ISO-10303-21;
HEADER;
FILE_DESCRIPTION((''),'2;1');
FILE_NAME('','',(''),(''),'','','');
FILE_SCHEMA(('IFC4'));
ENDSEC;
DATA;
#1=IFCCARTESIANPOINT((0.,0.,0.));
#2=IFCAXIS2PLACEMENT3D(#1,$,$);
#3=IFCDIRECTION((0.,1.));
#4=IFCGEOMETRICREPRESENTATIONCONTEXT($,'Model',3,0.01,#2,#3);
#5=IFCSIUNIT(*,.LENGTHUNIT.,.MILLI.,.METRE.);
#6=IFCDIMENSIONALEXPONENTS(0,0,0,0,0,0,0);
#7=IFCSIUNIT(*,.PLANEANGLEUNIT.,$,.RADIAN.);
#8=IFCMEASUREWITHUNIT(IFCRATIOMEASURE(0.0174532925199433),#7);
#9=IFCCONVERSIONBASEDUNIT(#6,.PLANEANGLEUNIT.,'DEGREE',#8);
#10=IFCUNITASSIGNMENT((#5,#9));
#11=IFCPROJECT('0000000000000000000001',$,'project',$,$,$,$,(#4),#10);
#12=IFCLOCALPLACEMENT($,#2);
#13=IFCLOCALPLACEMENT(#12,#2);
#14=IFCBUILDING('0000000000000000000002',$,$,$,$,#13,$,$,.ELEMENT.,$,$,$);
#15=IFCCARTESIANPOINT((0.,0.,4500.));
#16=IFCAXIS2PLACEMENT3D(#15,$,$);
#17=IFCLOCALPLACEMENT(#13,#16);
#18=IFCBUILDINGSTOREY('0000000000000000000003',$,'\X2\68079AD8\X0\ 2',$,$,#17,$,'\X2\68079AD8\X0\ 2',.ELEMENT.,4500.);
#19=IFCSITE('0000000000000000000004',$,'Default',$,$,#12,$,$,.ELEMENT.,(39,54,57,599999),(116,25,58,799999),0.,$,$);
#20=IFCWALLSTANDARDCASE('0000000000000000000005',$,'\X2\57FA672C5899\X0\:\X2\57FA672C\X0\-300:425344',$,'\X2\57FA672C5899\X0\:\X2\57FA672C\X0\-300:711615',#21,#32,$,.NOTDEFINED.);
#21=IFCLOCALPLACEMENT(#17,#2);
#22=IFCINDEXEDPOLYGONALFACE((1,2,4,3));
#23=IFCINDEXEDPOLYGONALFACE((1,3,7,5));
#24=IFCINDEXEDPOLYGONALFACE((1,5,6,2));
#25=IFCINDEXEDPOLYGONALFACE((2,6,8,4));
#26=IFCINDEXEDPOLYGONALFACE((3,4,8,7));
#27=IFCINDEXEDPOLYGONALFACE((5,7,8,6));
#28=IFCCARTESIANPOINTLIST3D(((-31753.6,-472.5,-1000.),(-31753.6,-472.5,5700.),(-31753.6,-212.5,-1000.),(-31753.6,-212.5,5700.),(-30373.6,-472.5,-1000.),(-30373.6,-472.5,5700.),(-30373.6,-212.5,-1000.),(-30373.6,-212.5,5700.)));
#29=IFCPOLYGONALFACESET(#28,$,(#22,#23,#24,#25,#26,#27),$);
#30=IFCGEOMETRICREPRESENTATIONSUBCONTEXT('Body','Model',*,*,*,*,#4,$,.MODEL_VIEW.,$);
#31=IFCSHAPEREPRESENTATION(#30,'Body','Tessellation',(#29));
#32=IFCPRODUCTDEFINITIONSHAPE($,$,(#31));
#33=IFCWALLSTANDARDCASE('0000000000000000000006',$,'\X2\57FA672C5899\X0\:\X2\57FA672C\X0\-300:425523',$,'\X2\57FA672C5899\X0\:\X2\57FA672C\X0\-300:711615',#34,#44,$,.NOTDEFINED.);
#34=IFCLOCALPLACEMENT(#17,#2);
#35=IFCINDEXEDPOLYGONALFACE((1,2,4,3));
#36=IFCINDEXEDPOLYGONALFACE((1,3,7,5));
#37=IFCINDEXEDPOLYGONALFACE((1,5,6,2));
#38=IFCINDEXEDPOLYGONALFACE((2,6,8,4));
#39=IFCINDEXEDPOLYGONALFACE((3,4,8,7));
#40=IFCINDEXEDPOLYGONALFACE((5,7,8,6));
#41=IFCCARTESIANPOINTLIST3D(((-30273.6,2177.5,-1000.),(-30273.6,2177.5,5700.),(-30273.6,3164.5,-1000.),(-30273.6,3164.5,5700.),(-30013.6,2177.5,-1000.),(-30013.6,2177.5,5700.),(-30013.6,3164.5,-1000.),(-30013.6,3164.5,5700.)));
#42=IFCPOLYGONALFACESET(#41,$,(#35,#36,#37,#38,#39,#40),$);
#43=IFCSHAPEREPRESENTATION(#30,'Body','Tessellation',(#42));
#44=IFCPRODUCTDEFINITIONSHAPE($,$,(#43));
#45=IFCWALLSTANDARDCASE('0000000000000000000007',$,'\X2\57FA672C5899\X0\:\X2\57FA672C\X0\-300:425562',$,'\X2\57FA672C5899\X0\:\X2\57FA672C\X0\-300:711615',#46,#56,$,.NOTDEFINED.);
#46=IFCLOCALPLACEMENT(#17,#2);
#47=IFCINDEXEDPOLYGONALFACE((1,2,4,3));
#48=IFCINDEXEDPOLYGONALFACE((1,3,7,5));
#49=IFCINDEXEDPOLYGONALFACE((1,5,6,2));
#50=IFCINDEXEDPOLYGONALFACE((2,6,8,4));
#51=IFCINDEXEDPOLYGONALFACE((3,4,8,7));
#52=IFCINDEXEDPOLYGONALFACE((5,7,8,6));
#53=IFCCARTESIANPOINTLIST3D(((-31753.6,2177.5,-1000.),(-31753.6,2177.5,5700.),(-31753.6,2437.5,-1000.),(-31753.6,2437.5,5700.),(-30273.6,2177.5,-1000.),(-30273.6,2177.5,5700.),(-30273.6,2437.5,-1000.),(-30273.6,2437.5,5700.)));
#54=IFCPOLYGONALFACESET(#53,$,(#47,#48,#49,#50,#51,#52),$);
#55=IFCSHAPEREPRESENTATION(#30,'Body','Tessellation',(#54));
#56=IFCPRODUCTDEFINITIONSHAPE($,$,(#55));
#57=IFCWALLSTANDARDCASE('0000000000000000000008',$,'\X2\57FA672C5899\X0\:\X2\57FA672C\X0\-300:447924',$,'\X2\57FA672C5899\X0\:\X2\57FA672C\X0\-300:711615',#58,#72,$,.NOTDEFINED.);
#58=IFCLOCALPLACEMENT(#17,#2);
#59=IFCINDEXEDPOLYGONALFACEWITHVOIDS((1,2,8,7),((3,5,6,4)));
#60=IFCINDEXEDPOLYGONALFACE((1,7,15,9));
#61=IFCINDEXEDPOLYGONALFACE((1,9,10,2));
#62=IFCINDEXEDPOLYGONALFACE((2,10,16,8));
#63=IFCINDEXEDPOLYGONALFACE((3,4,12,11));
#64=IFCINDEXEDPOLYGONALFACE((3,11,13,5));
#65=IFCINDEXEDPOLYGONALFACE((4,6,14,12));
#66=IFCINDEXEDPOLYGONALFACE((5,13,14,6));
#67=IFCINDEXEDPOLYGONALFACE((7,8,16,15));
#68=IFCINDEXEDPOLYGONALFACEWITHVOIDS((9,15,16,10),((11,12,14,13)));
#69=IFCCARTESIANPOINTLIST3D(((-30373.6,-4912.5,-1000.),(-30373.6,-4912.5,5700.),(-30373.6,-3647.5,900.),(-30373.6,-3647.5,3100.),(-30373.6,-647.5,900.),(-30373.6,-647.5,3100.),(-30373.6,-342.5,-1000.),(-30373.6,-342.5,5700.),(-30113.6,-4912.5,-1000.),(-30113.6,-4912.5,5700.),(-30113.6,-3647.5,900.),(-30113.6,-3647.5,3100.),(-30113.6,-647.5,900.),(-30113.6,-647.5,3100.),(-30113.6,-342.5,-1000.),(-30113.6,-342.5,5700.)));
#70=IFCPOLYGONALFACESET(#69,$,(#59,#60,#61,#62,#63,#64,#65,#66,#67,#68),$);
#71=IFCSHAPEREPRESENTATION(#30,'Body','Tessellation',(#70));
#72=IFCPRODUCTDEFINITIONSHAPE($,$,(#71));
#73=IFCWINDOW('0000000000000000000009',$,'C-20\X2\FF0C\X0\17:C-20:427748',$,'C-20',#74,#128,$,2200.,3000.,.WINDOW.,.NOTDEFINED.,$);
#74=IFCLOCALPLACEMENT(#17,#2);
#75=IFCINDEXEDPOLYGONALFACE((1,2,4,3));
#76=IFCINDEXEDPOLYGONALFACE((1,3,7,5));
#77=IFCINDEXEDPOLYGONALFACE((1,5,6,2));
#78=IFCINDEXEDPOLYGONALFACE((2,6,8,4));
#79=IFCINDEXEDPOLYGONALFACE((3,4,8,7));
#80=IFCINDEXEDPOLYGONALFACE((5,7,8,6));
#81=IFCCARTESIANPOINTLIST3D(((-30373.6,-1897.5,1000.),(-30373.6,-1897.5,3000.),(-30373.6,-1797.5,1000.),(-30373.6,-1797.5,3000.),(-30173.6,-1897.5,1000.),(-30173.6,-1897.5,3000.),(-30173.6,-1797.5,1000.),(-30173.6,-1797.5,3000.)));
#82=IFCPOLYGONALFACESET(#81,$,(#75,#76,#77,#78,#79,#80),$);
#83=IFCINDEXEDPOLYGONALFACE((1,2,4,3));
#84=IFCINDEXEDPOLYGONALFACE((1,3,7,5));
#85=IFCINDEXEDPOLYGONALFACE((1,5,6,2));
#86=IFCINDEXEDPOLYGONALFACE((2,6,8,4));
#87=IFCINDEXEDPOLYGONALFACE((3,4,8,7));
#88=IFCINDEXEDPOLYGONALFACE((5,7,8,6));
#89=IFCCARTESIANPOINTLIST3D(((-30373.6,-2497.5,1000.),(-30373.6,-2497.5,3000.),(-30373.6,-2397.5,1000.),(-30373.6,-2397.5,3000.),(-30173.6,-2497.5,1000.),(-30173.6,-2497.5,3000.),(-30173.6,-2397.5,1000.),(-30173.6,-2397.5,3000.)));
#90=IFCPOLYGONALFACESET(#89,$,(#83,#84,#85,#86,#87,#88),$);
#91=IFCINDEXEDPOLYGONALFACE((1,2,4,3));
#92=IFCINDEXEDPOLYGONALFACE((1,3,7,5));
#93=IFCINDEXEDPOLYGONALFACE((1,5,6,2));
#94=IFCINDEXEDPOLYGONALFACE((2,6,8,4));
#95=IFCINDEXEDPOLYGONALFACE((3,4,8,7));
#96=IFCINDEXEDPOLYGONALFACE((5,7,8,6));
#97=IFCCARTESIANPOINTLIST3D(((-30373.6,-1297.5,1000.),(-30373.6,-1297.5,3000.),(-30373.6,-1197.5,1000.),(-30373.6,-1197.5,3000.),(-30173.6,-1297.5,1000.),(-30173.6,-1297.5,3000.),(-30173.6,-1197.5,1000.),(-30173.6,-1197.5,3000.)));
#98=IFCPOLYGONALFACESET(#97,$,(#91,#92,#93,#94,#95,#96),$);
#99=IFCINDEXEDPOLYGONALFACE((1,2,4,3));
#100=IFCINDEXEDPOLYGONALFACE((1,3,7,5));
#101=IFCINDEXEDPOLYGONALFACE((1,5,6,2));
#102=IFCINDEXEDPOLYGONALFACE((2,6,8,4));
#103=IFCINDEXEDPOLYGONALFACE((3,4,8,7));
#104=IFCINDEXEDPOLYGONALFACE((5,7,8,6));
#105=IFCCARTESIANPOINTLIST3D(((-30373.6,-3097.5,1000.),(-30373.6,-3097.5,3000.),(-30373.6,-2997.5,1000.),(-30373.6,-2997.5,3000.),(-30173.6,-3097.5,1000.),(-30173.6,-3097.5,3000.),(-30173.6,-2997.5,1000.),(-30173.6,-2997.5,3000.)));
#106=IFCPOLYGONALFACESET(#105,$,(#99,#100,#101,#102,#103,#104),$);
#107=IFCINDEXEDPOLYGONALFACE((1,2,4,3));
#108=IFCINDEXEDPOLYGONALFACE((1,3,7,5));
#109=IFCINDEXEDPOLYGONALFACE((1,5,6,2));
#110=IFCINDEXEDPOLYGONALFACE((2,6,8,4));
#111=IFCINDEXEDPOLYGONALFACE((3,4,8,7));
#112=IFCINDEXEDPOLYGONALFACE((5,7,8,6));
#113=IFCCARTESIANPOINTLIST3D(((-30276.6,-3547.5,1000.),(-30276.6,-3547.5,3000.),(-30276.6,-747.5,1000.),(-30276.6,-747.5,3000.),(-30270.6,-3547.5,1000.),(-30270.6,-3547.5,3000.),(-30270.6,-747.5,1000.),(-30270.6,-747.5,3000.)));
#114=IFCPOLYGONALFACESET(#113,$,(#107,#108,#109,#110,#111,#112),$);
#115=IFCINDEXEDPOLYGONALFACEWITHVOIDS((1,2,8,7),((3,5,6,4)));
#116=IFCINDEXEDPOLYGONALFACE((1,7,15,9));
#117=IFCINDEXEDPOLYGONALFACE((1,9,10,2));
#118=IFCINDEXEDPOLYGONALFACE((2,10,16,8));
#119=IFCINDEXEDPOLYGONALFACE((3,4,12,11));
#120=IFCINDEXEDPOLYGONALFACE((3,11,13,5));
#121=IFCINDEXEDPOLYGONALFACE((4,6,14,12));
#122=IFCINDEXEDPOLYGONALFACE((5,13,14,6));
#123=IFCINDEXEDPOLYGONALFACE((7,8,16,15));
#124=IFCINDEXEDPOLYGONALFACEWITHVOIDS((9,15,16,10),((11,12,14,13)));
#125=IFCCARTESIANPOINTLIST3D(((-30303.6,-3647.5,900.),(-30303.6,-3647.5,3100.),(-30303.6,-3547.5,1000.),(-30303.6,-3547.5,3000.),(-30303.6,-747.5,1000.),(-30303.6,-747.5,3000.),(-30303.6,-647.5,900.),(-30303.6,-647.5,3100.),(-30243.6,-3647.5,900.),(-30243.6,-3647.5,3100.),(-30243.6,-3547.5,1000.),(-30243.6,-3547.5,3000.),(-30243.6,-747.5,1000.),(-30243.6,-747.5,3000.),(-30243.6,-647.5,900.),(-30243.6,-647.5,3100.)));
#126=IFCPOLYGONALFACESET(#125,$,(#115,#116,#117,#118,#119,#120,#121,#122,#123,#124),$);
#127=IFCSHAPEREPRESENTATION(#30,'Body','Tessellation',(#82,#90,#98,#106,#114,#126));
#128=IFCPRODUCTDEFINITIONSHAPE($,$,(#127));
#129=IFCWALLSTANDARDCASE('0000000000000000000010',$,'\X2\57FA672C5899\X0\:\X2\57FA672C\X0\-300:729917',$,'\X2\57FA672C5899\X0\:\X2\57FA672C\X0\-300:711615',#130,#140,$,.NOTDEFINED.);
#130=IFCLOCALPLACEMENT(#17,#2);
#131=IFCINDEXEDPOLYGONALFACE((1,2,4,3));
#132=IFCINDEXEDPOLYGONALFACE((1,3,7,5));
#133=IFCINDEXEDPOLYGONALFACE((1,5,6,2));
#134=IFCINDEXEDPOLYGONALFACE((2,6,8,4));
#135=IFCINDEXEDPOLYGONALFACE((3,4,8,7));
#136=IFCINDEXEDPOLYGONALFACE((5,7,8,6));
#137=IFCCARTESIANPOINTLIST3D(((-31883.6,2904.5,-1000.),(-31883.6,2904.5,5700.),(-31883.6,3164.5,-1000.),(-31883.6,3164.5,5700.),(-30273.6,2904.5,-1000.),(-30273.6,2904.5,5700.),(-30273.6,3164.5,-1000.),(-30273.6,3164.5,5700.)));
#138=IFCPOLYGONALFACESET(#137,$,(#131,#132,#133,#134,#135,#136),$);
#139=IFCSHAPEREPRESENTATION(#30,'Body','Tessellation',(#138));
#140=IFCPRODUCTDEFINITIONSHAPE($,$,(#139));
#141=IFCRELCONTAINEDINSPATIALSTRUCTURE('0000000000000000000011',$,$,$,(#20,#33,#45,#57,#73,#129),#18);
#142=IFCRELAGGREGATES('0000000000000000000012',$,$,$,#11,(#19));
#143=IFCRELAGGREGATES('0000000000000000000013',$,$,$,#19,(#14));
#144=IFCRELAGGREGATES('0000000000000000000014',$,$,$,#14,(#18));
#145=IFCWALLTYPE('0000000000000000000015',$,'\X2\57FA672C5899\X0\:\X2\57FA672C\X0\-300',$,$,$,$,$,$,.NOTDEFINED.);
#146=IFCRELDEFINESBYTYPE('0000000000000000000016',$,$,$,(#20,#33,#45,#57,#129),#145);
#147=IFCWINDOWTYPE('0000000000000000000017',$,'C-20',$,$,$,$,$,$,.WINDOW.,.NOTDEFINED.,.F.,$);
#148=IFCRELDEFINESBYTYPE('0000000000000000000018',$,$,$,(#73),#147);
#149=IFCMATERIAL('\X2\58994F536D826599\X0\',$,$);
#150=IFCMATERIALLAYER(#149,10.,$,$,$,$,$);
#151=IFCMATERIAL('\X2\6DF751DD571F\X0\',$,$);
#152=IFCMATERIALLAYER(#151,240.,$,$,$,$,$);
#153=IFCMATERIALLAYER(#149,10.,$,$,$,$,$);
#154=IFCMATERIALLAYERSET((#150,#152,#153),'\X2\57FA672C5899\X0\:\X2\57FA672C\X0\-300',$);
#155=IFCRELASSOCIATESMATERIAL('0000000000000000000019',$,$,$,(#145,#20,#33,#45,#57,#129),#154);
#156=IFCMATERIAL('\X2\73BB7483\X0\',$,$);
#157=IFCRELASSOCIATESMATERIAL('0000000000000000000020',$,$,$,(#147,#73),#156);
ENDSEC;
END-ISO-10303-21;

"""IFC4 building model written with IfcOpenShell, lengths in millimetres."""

from ifc_helpers import new_model, entity, si_unit, converted_unit, direction, frame, frame_2d, origin, origin_2d_with_axis, place, context, subcontext, project, spatial, polyline, rectangle, outline, extrude, source, transform, mapped, material, layer, layer_set, layer_usage, type_object, type_shapes, element, fill, save


model = new_model("IFC4")

# Units and contexts
model_context = context("Model", 3, precision=0.01, world=origin(), true_north=direction((0.0, 1.0)))
body_context = subcontext(model_context, "Body", "Model", "MODEL_VIEW")
ifc_project = project(units=[si_unit("LENGTHUNIT", "METRE", prefix="MILLI"), converted_unit("PLANEANGLEUNIT", "DEGREE", entity("IfcRatioMeasure", 0.0174532925199433), si_unit("PLANEANGLEUNIT", "RADIAN"), dimensions=[0, 0, 0, 0, 0, 0, 0])], contexts=[model_context])

# Site, building, storey
site_placement = place(None, origin())
site = spatial("IfcSite", under=ifc_project, at=site_placement, Name="Default", CompositionType="ELEMENT", RefLatitude=(39, 54, 57, 599999), RefLongitude=(116, 25, 58, 799999), RefElevation=0.0)
building_placement = place(site_placement, origin())
building = spatial("IfcBuilding", under=site, at=building_placement, CompositionType="ELEMENT")
storey_placement = place(building_placement, frame((0.0, 0.0, 4500.0)))
storey = spatial("IfcBuildingStorey", under=building, at=storey_placement, Name="标高 2", LongName="标高 2", CompositionType="ELEMENT", Elevation=4500.0)

# Shared definitions
ifc_material_1 = material(Name="混凝土")

# Shared definitions
ifc_material_2 = material(Name="墙体涂料")
ifc_layer_1 = layer(ifc_material_2, 10.0)
ifc_layer_2 = layer(ifc_material_1, 240.0)
ifc_layer_3 = layer(ifc_material_2, 10.0)
ifc_layer_set_1 = layer_set([ifc_layer_1, ifc_layer_2, ifc_layer_3], Name="基本墙:基本-300")
wall_type = type_object("IfcWallType", Name="基本墙:基本-300", PredefinedType="NOTDEFINED", material=ifc_layer_set_1)
ifc_material_3 = material(Name="玻璃")

# Walls
ifc_layer_usage_1 = layer_usage(ifc_layer_set_1, "AXIS2", "POSITIVE", -130.0)
wall_1_placement = place(storey_placement, frame((-31753.6, -342.5, -1000.0)))
element("IfcWallStandardCase", 1, at=wall_1_placement, inside=storey, type_object=wall_type, material=ifc_layer_usage_1, Name="基本墙:基本-300:425344", ObjectType="基本墙:基本-300:711615", PredefinedType="NOTDEFINED", context=body_context, shape_type="SweptSolid", body=[
    extrude(rectangle(XDim=1380.0, YDim=260.0, at=frame_2d((690.0, 0.0), x_axis=(-1.0, 0.0))), origin(), (0.0, 0.0, 1.0), 6700.0),
])
ifc_layer_usage_2 = layer_usage(ifc_layer_set_1, "AXIS2", "NEGATIVE", 130.0)
wall_2_placement = place(storey_placement, frame((-30143.6, 3164.5, -1000.0), z_axis=(0.0, 0.0, 1.0), x_axis=(0.0, -1.0, 0.0)))
element("IfcWallStandardCase", 2, at=wall_2_placement, inside=storey, type_object=wall_type, material=ifc_layer_usage_2, Name="基本墙:基本-300:425523", ObjectType="基本墙:基本-300:711615", PredefinedType="NOTDEFINED", context=body_context, shape_type="SweptSolid", body=[
    extrude(rectangle(XDim=987.0, YDim=260.0, at=frame_2d((493.5, 0.0), x_axis=(-1.0, 0.0))), origin(), (0.0, 0.0, 1.0), 6700.0),
])
ifc_layer_usage_3 = layer_usage(ifc_layer_set_1, "AXIS2", "NEGATIVE", 130.0)
wall_3_placement = place(storey_placement, frame((-30273.6, 2307.5, -1000.0), z_axis=(0.0, 0.0, 1.0), x_axis=(-1.0, 0.0, 0.0)))
element("IfcWallStandardCase", 3, at=wall_3_placement, inside=storey, type_object=wall_type, material=ifc_layer_usage_3, Name="基本墙:基本-300:425562", ObjectType="基本墙:基本-300:711615", PredefinedType="NOTDEFINED", context=body_context, shape_type="SweptSolid", body=[
    extrude(rectangle(XDim=1480.0, YDim=260.0, at=frame_2d((740.0, 0.0), x_axis=(-1.0, 0.0))), origin(), (0.0, 0.0, 1.0), 6700.0),
])

# Wall, opening, window
ifc_layer_usage_4 = layer_usage(ifc_layer_set_1, "AXIS2", "NEGATIVE", 130.0)
wall_4_placement = place(storey_placement, frame((-30243.6, -342.5, -1000.0), z_axis=(0.0, 0.0, 1.0), x_axis=(0.0, -1.0, 0.0)))
wall_4 = element("IfcWallStandardCase", 4, at=wall_4_placement, inside=storey, type_object=wall_type, material=ifc_layer_usage_4, Name="基本墙:基本-300:447924", ObjectType="基本墙:基本-300:711615", PredefinedType="NOTDEFINED", context=body_context, shape_type="SweptSolid", body=[
    extrude(rectangle(XDim=4570.0, YDim=260.0, at=frame_2d((2285.0, 0.0), x_axis=(-1.0, 0.0))), origin(), (0.0, 0.0, 1.0), 6700.0),
])
opening_1_placement = place(wall_4_placement, frame((305.0, -130.0, 1900.0)))
opening_1 = element("IfcOpeningElement", 5, at=opening_1_placement, cuts=wall_4, ObjectType="Opening", PredefinedType="OPENING", context=body_context, shape_type="SweptSolid", body=[
    extrude(rectangle(XDim=2200.0, YDim=3000.0, at=frame_2d((1100.0, 1500.0), x_axis=(1.0, 0.0))), frame((0.0, 0.0, 0.0), z_axis=(0.0, 1.0, 0.0), x_axis=(0.0, 0.0, 1.0)), (0.0, 0.0, 1.0), 260.0),
])
window_type = type_object("IfcWindowType", Name="C-20", ParameterTakesPrecedence=False, PartitioningType="NOTDEFINED", PredefinedType="WINDOW", material=ifc_material_3)
shared_shape_1 = source(origin(), body_context, "Body", "SweptSolid", [
    extrude(rectangle(XDim=100.0, YDim=200.0, at=origin_2d_with_axis()), frame((1200.0, 100.0, 100.0), z_axis=(0.0, 0.0, 1.0), x_axis=(-1.0, 0.0, 0.0)), (0.0, 0.0, 1.0), 2000.0),
    extrude(rectangle(XDim=100.0, YDim=200.0, at=origin_2d_with_axis()), frame((1800.0, 100.0, 100.0), z_axis=(0.0, 0.0, 1.0), x_axis=(-1.0, 0.0, 0.0)), (0.0, 0.0, 1.0), 2000.0),
    extrude(rectangle(XDim=100.0, YDim=200.0, at=origin_2d_with_axis()), frame((600.0, 100.0, 100.0), z_axis=(0.0, 0.0, 1.0), x_axis=(-1.0, 0.0, 0.0)), (0.0, 0.0, 1.0), 2000.0),
    extrude(rectangle(XDim=100.0, YDim=200.0, at=origin_2d_with_axis()), frame((2400.0, 100.0, 100.0), z_axis=(0.0, 0.0, 1.0), x_axis=(-1.0, 0.0, 0.0)), (0.0, 0.0, 1.0), 2000.0),
    extrude(rectangle(XDim=6.0, YDim=2800.0, at=frame_2d((0.0, 0.0), x_axis=(1.0, 0.0))), frame((1500.0, 100.0, 100.0), z_axis=(0.0, 0.0, 1.0), x_axis=(0.0, -1.0, 0.0)), (0.0, 0.0, 1.0), 2000.0),
    extrude(outline(polyline([(-1500.0, -1100.0), (1500.0, -1100.0), (1500.0, 1100.0), (-1500.0, 1100.0), (-1500.0, -1100.0)]), holes=[polyline([(-1400.0, -1000.0), (-1400.0, 1000.0), (1400.0, 1000.0), (1400.0, -1000.0), (-1400.0, -1000.0)])]), frame((1500.0, 70.0, 1100.0), z_axis=(0.0, 1.0, 0.0), x_axis=(1.0, 0.0, 0.0)), (0.0, 0.0, 1.0), 60.0),
])
type_shapes(window_type, [shared_shape_1])
window_placement = place(opening_1_placement, origin())
window = element("IfcWindow", 6, at=window_placement, inside=storey, type_object=window_type, material=ifc_material_3, Name="C-20，17:C-20:427748", ObjectType="C-20", OverallHeight=2200.0, OverallWidth=3000.0, PartitioningType="NOTDEFINED", PredefinedType="WINDOW", context=body_context, shape_type="MappedRepresentation", body=[
    mapped(shared_shape_1, transform((0.0, 0.0, 0.0), scale=1.0)),
])
fill(opening_1, window)

# Wall
ifc_layer_usage_5 = layer_usage(ifc_layer_set_1, "AXIS2", "NEGATIVE", 130.0)
wall_5_placement = place(storey_placement, frame((-31883.6, 3034.5, -1000.0)))
element("IfcWallStandardCase", 7, at=wall_5_placement, inside=storey, type_object=wall_type, material=ifc_layer_usage_5, Name="基本墙:基本-300:729917", ObjectType="基本墙:基本-300:711615", PredefinedType="NOTDEFINED", context=body_context, shape_type="SweptSolid", body=[
    extrude(rectangle(XDim=1610.0, YDim=260.0, at=frame_2d((805.0, 0.0), x_axis=(-1.0, 0.0))), origin(), (0.0, 0.0, 1.0), 6700.0),
])

save(model, "model.ifc")
